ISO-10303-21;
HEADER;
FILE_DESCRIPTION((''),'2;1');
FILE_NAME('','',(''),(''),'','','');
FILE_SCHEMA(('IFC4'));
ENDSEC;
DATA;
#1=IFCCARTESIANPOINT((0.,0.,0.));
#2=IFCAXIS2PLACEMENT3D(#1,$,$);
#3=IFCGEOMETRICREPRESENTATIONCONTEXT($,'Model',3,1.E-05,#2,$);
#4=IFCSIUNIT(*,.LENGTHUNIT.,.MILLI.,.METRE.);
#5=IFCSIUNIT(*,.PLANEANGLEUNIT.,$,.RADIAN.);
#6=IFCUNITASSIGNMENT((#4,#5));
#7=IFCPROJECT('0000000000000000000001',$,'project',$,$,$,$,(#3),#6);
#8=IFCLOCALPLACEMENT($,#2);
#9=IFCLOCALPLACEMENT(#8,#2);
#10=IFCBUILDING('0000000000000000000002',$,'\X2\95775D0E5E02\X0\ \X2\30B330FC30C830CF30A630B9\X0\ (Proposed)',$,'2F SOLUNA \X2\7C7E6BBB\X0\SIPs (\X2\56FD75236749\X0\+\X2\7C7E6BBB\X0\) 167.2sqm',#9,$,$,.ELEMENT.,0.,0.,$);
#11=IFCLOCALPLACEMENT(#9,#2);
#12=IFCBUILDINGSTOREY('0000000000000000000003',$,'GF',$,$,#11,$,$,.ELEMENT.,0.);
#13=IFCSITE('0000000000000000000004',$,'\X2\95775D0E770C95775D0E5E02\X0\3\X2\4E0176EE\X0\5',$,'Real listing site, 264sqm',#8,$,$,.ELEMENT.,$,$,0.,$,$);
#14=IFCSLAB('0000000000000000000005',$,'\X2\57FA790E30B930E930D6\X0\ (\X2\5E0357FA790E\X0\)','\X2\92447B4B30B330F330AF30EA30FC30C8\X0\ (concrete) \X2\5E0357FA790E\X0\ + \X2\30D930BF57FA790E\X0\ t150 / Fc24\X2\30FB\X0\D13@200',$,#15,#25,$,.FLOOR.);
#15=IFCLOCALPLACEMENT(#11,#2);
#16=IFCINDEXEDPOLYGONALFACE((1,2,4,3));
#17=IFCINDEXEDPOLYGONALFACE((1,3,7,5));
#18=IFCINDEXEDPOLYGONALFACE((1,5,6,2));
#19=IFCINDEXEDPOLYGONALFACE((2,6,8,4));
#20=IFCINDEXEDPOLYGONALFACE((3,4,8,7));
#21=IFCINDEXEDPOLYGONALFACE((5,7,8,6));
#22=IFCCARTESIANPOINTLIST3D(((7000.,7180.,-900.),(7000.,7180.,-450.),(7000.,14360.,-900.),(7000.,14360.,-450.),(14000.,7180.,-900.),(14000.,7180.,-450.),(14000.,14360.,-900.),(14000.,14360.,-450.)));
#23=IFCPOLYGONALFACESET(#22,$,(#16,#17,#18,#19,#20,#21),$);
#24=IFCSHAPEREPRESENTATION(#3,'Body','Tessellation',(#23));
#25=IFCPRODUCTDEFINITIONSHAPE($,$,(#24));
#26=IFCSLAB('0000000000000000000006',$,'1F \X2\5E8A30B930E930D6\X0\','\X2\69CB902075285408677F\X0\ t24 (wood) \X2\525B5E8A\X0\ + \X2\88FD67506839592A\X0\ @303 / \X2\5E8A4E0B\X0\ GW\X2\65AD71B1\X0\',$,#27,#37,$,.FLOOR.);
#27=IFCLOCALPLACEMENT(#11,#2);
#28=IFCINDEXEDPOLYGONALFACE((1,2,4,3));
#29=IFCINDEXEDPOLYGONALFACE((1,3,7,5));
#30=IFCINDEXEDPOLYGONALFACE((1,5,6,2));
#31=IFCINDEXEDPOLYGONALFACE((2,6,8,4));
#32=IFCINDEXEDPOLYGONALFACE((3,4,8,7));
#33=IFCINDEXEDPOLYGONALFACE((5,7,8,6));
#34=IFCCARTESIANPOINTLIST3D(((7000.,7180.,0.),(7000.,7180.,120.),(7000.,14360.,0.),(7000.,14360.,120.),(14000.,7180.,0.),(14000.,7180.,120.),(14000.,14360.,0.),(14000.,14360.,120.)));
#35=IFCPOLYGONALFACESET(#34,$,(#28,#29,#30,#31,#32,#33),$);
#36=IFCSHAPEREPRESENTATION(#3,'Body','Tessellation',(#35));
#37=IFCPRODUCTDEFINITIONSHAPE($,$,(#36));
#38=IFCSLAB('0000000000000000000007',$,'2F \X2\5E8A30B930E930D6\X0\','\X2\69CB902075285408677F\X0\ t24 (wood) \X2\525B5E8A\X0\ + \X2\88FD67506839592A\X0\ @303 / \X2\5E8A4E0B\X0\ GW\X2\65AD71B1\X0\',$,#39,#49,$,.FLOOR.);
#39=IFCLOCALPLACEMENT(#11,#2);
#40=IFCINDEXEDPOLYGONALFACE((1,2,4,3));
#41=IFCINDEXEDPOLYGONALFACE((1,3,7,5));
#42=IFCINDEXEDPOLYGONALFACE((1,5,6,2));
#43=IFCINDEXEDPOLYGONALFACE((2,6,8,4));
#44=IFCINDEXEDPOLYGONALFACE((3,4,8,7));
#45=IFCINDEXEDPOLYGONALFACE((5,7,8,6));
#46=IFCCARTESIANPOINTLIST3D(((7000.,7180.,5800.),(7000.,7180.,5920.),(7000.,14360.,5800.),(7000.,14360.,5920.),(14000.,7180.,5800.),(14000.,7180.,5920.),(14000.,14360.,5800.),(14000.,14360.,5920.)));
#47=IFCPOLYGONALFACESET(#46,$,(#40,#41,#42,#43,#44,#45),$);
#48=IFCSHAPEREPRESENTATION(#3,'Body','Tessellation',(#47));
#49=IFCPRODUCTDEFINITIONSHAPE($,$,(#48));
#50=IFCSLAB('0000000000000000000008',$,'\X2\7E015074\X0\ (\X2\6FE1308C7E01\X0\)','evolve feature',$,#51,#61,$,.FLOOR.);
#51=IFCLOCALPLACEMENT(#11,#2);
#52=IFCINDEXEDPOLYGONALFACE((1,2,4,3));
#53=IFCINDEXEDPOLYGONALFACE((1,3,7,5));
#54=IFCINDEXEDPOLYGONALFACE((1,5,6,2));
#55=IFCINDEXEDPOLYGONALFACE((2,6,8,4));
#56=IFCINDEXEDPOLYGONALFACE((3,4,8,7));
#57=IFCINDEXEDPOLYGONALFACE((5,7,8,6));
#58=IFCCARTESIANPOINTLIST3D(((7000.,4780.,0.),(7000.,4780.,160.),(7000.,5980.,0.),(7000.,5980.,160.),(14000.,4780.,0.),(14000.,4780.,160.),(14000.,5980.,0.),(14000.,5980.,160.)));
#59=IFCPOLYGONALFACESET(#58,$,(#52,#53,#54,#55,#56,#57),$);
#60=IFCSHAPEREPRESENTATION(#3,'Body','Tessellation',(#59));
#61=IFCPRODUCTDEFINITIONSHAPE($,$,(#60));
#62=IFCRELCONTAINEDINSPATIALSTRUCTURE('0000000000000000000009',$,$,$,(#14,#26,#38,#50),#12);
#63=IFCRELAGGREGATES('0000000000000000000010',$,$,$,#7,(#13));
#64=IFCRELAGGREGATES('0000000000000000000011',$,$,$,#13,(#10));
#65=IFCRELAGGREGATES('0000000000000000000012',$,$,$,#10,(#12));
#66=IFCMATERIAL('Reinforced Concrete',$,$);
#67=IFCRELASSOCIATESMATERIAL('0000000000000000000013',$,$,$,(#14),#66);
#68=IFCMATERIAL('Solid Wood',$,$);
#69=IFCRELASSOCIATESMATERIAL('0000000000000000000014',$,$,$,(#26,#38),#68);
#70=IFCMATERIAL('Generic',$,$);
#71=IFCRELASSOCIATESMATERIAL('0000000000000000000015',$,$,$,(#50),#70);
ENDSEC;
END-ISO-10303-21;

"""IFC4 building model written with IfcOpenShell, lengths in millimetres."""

from ifc_helpers import new_model, si_unit, frame, frame_2d, origin, place, context, project, spatial, rectangle, extrude, material, element, save


model = new_model("IFC4")

# Units and contexts
model_context = context("Model", 3, precision=1e-05, world=origin())
ifc_project = project(units=[si_unit("LENGTHUNIT", "METRE", prefix="MILLI"), si_unit("PLANEANGLEUNIT", "RADIAN")], contexts=[model_context])

# Site, building, storey
site_placement = place(None, origin())
site = spatial("IfcSite", under=ifc_project, at=site_placement, Name="長崎県長崎市3丁目5", ObjectType="Real listing site, 264sqm", CompositionType="ELEMENT", RefElevation=0.0)
building_placement = place(site_placement, origin())
building = spatial("IfcBuilding", under=site, at=building_placement, Name="長崎市 コートハウス (Proposed)", ObjectType="2F SOLUNA 籾殻SIPs (国産杉+籾殻) 167.2sqm", CompositionType="ELEMENT", ElevationOfRefHeight=0.0, ElevationOfTerrain=0.0)
storey_placement = place(building_placement, origin())
storey = spatial("IfcBuildingStorey", under=building, at=storey_placement, Name="GF", CompositionType="ELEMENT", Elevation=0.0)

# Slabs
ifc_material_1 = material(Name="Reinforced Concrete")
slab_1_placement = place(storey_placement, frame((3500.0, 3590.0, -450.0)))
element("IfcSlab", 1, at=slab_1_placement, inside=storey, material=ifc_material_1, Name="基礎スラブ (布基礎)", Description="鉄筋コンクリート (concrete) 布基礎 + ベタ基礎 t150 / Fc24・D13@200", PredefinedType="FLOOR", context=model_context, shape_type="SweptSolid", body=[
    extrude(rectangle(XDim=7000.0, YDim=7180.0, at=frame_2d((3500.0, 3590.0))), frame((3500.0, 3590.0, -450.0)), (0.0, 0.0, 1.0), 450.0),
])
ifc_material_2 = material(Name="Solid Wood")
slab_2_placement = place(storey_placement, frame((3500.0, 3590.0, 0.0)))
element("IfcSlab", 2, at=slab_2_placement, inside=storey, material=ifc_material_2, Name="1F 床スラブ", Description="構造用合板 t24 (wood) 剛床 + 製材根太 @303 / 床下 GW断熱", PredefinedType="FLOOR", context=model_context, shape_type="SweptSolid", body=[
    extrude(rectangle(XDim=7000.0, YDim=7180.0, at=frame_2d((3500.0, 3590.0))), frame((3500.0, 3590.0, 0.0)), (0.0, 0.0, 1.0), 120.0),
])
slab_3_placement = place(storey_placement, frame((3500.0, 3590.0, 2900.0)))
element("IfcSlab", 3, at=slab_3_placement, inside=storey, material=ifc_material_2, Name="2F 床スラブ", Description="構造用合板 t24 (wood) 剛床 + 製材根太 @303 / 床下 GW断熱", PredefinedType="FLOOR", context=model_context, shape_type="SweptSolid", body=[
    extrude(rectangle(XDim=7000.0, YDim=7180.0, at=frame_2d((3500.0, 3590.0))), frame((3500.0, 3590.0, 2900.0)), (0.0, 0.0, 1.0), 120.0),
])
ifc_material_3 = material(Name="Generic")
slab_4_placement = place(storey_placement, frame((3500.0, 2390.0, 0.0)))
element("IfcSlab", 4, at=slab_4_placement, inside=storey, material=ifc_material_3, Name="縁側 (濡れ縁)", Description="evolve feature", PredefinedType="FLOOR", context=model_context, shape_type="SweptSolid", body=[
    extrude(rectangle(XDim=7000.0, YDim=1200.0, at=frame_2d((3500.0, 600.0))), frame((3500.0, 2390.0, 0.0)), (0.0, 0.0, 1.0), 160.0),
])

save(model, "model.ifc")
